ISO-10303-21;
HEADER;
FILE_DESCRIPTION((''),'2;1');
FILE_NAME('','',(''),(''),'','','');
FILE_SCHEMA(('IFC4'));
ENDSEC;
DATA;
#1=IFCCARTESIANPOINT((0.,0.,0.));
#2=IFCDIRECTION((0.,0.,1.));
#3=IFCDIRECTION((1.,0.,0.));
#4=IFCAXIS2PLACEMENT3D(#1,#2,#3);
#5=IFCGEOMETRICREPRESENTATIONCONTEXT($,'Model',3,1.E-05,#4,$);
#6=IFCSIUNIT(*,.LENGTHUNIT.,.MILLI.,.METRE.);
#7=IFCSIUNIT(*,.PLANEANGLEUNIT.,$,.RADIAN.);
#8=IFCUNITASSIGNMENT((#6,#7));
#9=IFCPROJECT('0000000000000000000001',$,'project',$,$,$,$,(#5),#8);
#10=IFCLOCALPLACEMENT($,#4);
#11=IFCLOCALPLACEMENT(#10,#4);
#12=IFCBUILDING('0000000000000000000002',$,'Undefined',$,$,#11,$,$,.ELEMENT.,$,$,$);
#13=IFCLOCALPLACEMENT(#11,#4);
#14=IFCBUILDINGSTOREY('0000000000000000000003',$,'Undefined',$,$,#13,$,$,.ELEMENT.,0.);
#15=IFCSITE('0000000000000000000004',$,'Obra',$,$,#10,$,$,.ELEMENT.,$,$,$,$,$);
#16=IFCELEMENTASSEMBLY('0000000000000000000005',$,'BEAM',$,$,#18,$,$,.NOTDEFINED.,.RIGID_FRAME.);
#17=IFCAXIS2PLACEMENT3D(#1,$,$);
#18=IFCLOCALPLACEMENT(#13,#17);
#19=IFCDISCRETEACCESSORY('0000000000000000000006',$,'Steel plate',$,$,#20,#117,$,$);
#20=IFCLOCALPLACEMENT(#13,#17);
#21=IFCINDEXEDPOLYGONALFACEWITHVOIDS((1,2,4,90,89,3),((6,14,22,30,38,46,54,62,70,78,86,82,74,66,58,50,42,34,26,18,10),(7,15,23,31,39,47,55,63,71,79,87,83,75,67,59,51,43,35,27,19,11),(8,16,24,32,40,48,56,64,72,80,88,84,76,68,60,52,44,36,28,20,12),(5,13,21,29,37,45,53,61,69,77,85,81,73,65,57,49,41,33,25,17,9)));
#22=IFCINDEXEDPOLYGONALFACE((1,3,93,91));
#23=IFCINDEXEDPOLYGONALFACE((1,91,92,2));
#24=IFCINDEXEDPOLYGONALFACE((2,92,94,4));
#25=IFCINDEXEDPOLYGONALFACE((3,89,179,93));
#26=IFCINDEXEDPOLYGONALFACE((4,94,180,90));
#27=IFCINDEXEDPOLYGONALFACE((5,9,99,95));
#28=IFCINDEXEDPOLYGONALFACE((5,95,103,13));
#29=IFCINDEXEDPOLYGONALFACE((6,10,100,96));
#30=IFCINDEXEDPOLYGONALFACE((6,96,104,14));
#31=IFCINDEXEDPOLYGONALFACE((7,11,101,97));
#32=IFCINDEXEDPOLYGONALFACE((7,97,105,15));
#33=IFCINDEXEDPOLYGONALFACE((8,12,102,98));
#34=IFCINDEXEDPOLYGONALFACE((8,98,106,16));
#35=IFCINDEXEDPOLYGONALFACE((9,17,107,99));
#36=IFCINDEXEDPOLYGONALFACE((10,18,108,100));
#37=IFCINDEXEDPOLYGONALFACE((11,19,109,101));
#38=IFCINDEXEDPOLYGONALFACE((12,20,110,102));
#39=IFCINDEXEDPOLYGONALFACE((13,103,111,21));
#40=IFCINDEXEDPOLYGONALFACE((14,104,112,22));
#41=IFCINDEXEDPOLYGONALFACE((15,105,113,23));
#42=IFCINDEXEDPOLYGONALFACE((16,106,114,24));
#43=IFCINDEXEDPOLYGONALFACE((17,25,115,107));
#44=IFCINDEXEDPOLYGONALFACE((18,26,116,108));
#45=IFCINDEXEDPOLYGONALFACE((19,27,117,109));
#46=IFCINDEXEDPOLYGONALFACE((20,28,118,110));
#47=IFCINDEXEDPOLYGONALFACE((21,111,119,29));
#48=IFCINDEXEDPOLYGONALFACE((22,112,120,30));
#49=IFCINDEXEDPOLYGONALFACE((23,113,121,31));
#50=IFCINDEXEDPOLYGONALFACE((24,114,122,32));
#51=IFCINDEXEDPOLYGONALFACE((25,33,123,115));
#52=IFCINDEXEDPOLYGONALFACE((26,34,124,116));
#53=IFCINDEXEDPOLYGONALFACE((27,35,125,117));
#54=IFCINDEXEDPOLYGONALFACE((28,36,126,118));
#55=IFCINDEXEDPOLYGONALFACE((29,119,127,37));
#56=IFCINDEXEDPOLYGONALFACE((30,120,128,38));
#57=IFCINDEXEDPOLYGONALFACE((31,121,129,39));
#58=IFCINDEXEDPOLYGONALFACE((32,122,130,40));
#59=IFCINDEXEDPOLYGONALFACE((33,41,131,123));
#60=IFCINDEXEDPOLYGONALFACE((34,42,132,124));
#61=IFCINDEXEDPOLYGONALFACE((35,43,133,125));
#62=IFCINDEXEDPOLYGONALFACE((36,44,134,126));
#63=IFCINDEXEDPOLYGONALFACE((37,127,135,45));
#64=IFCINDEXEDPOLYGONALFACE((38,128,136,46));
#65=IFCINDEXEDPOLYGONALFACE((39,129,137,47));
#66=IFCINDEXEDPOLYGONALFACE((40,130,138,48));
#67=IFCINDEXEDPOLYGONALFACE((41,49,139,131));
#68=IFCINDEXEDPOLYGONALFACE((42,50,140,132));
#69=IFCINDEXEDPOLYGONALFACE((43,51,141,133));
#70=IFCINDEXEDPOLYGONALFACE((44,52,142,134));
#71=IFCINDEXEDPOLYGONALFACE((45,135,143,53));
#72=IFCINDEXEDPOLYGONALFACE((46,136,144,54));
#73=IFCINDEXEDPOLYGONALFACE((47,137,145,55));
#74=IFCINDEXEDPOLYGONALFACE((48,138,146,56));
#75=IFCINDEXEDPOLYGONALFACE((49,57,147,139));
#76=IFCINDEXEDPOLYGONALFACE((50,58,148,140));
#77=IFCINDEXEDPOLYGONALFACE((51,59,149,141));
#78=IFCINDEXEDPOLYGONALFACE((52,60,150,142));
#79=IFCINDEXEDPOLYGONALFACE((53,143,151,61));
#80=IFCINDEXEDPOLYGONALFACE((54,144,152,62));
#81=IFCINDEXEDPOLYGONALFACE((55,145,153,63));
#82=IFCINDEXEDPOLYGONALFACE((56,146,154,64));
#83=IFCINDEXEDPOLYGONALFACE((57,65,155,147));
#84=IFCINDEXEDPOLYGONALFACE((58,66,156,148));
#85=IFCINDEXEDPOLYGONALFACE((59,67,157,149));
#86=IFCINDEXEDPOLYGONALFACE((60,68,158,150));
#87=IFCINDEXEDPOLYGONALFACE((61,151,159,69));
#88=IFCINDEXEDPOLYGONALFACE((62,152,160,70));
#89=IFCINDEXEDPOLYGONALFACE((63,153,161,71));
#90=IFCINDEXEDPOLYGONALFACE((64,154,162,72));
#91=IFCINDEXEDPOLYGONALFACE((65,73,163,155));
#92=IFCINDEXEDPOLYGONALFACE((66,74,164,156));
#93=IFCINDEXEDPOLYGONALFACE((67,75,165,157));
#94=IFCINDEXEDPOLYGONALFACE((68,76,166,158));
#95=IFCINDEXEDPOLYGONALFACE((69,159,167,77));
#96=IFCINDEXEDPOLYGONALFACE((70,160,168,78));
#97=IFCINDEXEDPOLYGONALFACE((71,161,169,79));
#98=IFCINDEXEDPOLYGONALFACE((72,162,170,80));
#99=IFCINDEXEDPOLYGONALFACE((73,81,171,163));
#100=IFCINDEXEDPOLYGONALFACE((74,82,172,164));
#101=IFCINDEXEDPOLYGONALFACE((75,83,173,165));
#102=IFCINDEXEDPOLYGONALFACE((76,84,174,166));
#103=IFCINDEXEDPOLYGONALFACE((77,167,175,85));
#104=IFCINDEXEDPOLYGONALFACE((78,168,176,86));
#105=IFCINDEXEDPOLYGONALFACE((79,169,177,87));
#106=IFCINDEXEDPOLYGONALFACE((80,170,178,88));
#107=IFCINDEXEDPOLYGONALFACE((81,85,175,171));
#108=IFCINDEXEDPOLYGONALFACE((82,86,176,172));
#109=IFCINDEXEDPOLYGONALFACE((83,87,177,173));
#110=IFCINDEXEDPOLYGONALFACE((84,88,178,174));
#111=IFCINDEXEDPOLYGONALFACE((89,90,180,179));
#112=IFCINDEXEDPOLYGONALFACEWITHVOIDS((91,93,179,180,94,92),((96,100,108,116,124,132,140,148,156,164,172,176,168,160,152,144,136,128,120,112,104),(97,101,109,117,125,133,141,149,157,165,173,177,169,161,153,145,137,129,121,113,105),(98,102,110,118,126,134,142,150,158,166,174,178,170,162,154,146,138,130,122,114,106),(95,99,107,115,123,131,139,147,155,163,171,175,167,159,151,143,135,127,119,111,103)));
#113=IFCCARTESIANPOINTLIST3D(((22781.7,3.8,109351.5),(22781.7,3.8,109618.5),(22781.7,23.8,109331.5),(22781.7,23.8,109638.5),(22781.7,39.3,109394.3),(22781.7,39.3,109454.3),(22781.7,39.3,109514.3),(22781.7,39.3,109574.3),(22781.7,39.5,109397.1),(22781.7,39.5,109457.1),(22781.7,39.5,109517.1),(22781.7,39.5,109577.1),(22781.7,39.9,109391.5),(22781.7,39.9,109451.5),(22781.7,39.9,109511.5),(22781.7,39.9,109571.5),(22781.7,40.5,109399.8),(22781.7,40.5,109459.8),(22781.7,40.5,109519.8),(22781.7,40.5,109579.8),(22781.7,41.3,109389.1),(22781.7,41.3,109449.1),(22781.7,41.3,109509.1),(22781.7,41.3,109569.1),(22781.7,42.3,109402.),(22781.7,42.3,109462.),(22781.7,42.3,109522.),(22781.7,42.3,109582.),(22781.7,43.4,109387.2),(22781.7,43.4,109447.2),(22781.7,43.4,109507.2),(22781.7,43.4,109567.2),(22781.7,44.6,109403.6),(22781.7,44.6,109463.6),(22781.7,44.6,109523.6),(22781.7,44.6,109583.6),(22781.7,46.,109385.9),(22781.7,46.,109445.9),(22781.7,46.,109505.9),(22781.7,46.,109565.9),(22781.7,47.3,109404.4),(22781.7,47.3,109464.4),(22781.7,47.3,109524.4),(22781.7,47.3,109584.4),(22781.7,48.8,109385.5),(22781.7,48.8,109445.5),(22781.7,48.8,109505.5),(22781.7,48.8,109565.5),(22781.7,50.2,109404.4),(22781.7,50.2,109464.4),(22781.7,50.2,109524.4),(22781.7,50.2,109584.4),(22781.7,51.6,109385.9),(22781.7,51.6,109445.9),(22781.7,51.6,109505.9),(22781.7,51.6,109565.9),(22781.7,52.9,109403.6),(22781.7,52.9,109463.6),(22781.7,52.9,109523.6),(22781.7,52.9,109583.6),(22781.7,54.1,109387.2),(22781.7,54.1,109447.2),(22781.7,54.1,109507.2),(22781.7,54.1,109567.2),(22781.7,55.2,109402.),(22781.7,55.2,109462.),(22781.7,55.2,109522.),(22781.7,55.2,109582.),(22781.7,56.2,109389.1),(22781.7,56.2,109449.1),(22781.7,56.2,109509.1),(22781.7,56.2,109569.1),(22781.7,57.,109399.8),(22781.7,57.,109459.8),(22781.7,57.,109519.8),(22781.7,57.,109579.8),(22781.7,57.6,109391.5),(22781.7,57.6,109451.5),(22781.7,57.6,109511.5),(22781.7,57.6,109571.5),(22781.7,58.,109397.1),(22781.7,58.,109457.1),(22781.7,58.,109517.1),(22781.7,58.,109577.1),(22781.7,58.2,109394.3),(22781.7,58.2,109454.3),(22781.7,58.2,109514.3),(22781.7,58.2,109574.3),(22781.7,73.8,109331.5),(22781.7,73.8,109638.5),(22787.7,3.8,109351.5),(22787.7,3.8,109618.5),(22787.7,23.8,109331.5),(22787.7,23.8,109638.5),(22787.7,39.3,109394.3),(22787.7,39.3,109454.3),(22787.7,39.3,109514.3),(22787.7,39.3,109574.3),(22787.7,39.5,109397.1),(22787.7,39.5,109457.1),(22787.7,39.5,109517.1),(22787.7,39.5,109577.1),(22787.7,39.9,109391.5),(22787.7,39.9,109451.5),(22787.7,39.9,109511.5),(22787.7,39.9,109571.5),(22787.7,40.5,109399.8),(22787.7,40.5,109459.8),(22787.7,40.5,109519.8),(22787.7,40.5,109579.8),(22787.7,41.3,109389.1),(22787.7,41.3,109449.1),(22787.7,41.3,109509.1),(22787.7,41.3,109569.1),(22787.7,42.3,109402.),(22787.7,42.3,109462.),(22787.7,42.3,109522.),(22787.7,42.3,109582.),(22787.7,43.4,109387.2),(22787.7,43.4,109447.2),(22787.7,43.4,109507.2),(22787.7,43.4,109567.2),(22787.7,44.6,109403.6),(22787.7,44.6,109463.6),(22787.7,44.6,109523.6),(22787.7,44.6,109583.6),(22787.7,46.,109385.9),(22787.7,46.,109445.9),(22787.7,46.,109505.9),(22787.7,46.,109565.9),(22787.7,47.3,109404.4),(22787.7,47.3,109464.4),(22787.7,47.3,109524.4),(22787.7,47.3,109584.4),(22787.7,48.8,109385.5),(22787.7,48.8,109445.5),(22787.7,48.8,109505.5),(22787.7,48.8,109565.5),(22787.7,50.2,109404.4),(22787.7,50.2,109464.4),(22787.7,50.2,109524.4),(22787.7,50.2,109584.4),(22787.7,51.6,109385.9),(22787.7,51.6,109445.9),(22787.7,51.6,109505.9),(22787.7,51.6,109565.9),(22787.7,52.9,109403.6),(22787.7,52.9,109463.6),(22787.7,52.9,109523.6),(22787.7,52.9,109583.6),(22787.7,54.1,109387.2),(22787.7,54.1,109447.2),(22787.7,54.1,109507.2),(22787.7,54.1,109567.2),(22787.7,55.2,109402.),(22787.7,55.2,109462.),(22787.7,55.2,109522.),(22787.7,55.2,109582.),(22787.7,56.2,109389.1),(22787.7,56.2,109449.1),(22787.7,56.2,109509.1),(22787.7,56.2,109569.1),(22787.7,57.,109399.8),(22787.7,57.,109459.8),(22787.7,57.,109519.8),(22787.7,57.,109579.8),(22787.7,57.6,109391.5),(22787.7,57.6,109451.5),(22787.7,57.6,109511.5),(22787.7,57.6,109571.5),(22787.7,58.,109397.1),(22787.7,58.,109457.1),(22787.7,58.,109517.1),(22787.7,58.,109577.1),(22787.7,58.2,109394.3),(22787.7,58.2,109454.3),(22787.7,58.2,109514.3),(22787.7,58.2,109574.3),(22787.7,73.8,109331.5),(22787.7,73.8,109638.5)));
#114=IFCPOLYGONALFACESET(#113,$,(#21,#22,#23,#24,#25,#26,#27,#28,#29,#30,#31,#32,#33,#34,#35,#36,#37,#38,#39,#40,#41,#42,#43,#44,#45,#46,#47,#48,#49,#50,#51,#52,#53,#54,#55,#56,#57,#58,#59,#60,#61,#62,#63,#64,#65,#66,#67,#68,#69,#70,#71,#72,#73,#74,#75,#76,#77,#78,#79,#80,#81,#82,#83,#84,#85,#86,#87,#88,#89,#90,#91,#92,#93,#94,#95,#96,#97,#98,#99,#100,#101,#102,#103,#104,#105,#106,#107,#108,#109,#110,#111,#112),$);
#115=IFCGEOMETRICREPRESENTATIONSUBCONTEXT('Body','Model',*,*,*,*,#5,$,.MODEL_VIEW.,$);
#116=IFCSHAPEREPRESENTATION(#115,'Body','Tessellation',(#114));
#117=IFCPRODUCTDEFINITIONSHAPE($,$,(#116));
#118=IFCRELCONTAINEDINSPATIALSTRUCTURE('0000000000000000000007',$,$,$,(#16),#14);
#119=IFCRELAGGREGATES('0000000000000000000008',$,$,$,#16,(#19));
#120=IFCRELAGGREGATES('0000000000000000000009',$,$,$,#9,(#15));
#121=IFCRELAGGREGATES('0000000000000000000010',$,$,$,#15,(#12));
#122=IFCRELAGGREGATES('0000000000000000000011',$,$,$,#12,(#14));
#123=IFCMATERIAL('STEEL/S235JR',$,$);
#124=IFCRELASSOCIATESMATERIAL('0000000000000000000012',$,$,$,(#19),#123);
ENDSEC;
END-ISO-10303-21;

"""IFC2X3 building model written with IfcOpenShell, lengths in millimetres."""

from ifc_helpers import new_model, si_unit, frame, origin_with_axes, origin_2d_with_axis, place, context, subcontext, project, spatial, polyline, circle, outline, extrude, source, transform, mapped, material, element, aggregate, save


model = new_model("IFC2X3")

# Units and contexts
model_context = context("Model", 3, precision=1e-05, world=origin_with_axes())
body_context = subcontext(model_context, "Body", "Model", "MODEL_VIEW")
ifc_project = project(units=[si_unit("LENGTHUNIT", "METRE", prefix="MILLI"), si_unit("PLANEANGLEUNIT", "RADIAN")], contexts=[model_context])

# Site, building, storey
site_placement = place(None, origin_with_axes())
site = spatial("IfcSite", under=ifc_project, at=site_placement, Name="Obra", CompositionType="ELEMENT")
building_placement = place(site_placement, origin_with_axes())
building = spatial("IfcBuilding", under=site, at=building_placement, Name="Undefined", CompositionType="ELEMENT")
storey_placement = place(building_placement, origin_with_axes())
storey = spatial("IfcBuildingStorey", under=building, at=storey_placement, Name="Undefined", CompositionType="ELEMENT", Elevation=0.0)

# Shared definitions
ifc_material = material(Name="STEEL/S235JR")
shared_shape = source(origin_with_axes(), body_context, "Body", "SweptSolid", [
    extrude(circle(Radius=9.5, at=origin_2d_with_axis()), frame((0.0, -9.8, 0.0), z_axis=(0.0, 1.0, 0.0), x_axis=(1.0, 0.0, 0.0)), (0.0, 0.0, 1.0), 6.2),
])

# Element assembly, discrete accessory, opening
assembly_1_placement = place(storey_placement, origin_with_axes())
assembly_1 = element("IfcElementAssembly", 1, at=assembly_1_placement, inside=storey, Name="BEAM", AssemblyPlace="NOTDEFINED", PredefinedType="RIGID_FRAME")
discrete_accessory_1_placement = place(assembly_1_placement, frame((22784.7, 73.8, 109331.5), z_axis=(-1.0, 0.0, 0.0), x_axis=(0.0, -1.0, 0.0)))
discrete_accessory_1 = element("IfcDiscreteAccessory", 2, at=discrete_accessory_1_placement, material=ifc_material, Name="Steel plate", context=body_context, shape_type="SweptSolid", body=[
    extrude(outline(polyline([(0.0, 0.0), (50.0, 0.0), (70.0, 20.0), (70.0, 287.0), (50.0, 307.0), (0.0, 307.0), (0.0, 0.0)])), frame((0.0, 0.0, -3.0), z_axis=(0.0, 0.0, 1.0), x_axis=(1.0, 0.0, 0.0)), (0.0, 0.0, 1.0), 6.0),
])
opening_1_placement = place(assembly_1_placement, frame((22778.0, 13.8, 109650.0), z_axis=(0.0, 1.0, 0.0), x_axis=(0.0, 0.0, -1.0)))
element("IfcOpeningElement", 3, at=opening_1_placement, cuts=discrete_accessory_1, ObjectType="Opening", context=body_context, shape_type="MappedRepresentation", body=[
    mapped(shared_shape, transform((75.0, 0.0, 35.0))),
    mapped(shared_shape, transform((135.0, 0.0, 35.0))),
    mapped(shared_shape, transform((195.0, 0.0, 35.0))),
    mapped(shared_shape, transform((255.0, 0.0, 35.0))),
])
aggregate(assembly_1, [discrete_accessory_1])

save(model, "model.ifc")
